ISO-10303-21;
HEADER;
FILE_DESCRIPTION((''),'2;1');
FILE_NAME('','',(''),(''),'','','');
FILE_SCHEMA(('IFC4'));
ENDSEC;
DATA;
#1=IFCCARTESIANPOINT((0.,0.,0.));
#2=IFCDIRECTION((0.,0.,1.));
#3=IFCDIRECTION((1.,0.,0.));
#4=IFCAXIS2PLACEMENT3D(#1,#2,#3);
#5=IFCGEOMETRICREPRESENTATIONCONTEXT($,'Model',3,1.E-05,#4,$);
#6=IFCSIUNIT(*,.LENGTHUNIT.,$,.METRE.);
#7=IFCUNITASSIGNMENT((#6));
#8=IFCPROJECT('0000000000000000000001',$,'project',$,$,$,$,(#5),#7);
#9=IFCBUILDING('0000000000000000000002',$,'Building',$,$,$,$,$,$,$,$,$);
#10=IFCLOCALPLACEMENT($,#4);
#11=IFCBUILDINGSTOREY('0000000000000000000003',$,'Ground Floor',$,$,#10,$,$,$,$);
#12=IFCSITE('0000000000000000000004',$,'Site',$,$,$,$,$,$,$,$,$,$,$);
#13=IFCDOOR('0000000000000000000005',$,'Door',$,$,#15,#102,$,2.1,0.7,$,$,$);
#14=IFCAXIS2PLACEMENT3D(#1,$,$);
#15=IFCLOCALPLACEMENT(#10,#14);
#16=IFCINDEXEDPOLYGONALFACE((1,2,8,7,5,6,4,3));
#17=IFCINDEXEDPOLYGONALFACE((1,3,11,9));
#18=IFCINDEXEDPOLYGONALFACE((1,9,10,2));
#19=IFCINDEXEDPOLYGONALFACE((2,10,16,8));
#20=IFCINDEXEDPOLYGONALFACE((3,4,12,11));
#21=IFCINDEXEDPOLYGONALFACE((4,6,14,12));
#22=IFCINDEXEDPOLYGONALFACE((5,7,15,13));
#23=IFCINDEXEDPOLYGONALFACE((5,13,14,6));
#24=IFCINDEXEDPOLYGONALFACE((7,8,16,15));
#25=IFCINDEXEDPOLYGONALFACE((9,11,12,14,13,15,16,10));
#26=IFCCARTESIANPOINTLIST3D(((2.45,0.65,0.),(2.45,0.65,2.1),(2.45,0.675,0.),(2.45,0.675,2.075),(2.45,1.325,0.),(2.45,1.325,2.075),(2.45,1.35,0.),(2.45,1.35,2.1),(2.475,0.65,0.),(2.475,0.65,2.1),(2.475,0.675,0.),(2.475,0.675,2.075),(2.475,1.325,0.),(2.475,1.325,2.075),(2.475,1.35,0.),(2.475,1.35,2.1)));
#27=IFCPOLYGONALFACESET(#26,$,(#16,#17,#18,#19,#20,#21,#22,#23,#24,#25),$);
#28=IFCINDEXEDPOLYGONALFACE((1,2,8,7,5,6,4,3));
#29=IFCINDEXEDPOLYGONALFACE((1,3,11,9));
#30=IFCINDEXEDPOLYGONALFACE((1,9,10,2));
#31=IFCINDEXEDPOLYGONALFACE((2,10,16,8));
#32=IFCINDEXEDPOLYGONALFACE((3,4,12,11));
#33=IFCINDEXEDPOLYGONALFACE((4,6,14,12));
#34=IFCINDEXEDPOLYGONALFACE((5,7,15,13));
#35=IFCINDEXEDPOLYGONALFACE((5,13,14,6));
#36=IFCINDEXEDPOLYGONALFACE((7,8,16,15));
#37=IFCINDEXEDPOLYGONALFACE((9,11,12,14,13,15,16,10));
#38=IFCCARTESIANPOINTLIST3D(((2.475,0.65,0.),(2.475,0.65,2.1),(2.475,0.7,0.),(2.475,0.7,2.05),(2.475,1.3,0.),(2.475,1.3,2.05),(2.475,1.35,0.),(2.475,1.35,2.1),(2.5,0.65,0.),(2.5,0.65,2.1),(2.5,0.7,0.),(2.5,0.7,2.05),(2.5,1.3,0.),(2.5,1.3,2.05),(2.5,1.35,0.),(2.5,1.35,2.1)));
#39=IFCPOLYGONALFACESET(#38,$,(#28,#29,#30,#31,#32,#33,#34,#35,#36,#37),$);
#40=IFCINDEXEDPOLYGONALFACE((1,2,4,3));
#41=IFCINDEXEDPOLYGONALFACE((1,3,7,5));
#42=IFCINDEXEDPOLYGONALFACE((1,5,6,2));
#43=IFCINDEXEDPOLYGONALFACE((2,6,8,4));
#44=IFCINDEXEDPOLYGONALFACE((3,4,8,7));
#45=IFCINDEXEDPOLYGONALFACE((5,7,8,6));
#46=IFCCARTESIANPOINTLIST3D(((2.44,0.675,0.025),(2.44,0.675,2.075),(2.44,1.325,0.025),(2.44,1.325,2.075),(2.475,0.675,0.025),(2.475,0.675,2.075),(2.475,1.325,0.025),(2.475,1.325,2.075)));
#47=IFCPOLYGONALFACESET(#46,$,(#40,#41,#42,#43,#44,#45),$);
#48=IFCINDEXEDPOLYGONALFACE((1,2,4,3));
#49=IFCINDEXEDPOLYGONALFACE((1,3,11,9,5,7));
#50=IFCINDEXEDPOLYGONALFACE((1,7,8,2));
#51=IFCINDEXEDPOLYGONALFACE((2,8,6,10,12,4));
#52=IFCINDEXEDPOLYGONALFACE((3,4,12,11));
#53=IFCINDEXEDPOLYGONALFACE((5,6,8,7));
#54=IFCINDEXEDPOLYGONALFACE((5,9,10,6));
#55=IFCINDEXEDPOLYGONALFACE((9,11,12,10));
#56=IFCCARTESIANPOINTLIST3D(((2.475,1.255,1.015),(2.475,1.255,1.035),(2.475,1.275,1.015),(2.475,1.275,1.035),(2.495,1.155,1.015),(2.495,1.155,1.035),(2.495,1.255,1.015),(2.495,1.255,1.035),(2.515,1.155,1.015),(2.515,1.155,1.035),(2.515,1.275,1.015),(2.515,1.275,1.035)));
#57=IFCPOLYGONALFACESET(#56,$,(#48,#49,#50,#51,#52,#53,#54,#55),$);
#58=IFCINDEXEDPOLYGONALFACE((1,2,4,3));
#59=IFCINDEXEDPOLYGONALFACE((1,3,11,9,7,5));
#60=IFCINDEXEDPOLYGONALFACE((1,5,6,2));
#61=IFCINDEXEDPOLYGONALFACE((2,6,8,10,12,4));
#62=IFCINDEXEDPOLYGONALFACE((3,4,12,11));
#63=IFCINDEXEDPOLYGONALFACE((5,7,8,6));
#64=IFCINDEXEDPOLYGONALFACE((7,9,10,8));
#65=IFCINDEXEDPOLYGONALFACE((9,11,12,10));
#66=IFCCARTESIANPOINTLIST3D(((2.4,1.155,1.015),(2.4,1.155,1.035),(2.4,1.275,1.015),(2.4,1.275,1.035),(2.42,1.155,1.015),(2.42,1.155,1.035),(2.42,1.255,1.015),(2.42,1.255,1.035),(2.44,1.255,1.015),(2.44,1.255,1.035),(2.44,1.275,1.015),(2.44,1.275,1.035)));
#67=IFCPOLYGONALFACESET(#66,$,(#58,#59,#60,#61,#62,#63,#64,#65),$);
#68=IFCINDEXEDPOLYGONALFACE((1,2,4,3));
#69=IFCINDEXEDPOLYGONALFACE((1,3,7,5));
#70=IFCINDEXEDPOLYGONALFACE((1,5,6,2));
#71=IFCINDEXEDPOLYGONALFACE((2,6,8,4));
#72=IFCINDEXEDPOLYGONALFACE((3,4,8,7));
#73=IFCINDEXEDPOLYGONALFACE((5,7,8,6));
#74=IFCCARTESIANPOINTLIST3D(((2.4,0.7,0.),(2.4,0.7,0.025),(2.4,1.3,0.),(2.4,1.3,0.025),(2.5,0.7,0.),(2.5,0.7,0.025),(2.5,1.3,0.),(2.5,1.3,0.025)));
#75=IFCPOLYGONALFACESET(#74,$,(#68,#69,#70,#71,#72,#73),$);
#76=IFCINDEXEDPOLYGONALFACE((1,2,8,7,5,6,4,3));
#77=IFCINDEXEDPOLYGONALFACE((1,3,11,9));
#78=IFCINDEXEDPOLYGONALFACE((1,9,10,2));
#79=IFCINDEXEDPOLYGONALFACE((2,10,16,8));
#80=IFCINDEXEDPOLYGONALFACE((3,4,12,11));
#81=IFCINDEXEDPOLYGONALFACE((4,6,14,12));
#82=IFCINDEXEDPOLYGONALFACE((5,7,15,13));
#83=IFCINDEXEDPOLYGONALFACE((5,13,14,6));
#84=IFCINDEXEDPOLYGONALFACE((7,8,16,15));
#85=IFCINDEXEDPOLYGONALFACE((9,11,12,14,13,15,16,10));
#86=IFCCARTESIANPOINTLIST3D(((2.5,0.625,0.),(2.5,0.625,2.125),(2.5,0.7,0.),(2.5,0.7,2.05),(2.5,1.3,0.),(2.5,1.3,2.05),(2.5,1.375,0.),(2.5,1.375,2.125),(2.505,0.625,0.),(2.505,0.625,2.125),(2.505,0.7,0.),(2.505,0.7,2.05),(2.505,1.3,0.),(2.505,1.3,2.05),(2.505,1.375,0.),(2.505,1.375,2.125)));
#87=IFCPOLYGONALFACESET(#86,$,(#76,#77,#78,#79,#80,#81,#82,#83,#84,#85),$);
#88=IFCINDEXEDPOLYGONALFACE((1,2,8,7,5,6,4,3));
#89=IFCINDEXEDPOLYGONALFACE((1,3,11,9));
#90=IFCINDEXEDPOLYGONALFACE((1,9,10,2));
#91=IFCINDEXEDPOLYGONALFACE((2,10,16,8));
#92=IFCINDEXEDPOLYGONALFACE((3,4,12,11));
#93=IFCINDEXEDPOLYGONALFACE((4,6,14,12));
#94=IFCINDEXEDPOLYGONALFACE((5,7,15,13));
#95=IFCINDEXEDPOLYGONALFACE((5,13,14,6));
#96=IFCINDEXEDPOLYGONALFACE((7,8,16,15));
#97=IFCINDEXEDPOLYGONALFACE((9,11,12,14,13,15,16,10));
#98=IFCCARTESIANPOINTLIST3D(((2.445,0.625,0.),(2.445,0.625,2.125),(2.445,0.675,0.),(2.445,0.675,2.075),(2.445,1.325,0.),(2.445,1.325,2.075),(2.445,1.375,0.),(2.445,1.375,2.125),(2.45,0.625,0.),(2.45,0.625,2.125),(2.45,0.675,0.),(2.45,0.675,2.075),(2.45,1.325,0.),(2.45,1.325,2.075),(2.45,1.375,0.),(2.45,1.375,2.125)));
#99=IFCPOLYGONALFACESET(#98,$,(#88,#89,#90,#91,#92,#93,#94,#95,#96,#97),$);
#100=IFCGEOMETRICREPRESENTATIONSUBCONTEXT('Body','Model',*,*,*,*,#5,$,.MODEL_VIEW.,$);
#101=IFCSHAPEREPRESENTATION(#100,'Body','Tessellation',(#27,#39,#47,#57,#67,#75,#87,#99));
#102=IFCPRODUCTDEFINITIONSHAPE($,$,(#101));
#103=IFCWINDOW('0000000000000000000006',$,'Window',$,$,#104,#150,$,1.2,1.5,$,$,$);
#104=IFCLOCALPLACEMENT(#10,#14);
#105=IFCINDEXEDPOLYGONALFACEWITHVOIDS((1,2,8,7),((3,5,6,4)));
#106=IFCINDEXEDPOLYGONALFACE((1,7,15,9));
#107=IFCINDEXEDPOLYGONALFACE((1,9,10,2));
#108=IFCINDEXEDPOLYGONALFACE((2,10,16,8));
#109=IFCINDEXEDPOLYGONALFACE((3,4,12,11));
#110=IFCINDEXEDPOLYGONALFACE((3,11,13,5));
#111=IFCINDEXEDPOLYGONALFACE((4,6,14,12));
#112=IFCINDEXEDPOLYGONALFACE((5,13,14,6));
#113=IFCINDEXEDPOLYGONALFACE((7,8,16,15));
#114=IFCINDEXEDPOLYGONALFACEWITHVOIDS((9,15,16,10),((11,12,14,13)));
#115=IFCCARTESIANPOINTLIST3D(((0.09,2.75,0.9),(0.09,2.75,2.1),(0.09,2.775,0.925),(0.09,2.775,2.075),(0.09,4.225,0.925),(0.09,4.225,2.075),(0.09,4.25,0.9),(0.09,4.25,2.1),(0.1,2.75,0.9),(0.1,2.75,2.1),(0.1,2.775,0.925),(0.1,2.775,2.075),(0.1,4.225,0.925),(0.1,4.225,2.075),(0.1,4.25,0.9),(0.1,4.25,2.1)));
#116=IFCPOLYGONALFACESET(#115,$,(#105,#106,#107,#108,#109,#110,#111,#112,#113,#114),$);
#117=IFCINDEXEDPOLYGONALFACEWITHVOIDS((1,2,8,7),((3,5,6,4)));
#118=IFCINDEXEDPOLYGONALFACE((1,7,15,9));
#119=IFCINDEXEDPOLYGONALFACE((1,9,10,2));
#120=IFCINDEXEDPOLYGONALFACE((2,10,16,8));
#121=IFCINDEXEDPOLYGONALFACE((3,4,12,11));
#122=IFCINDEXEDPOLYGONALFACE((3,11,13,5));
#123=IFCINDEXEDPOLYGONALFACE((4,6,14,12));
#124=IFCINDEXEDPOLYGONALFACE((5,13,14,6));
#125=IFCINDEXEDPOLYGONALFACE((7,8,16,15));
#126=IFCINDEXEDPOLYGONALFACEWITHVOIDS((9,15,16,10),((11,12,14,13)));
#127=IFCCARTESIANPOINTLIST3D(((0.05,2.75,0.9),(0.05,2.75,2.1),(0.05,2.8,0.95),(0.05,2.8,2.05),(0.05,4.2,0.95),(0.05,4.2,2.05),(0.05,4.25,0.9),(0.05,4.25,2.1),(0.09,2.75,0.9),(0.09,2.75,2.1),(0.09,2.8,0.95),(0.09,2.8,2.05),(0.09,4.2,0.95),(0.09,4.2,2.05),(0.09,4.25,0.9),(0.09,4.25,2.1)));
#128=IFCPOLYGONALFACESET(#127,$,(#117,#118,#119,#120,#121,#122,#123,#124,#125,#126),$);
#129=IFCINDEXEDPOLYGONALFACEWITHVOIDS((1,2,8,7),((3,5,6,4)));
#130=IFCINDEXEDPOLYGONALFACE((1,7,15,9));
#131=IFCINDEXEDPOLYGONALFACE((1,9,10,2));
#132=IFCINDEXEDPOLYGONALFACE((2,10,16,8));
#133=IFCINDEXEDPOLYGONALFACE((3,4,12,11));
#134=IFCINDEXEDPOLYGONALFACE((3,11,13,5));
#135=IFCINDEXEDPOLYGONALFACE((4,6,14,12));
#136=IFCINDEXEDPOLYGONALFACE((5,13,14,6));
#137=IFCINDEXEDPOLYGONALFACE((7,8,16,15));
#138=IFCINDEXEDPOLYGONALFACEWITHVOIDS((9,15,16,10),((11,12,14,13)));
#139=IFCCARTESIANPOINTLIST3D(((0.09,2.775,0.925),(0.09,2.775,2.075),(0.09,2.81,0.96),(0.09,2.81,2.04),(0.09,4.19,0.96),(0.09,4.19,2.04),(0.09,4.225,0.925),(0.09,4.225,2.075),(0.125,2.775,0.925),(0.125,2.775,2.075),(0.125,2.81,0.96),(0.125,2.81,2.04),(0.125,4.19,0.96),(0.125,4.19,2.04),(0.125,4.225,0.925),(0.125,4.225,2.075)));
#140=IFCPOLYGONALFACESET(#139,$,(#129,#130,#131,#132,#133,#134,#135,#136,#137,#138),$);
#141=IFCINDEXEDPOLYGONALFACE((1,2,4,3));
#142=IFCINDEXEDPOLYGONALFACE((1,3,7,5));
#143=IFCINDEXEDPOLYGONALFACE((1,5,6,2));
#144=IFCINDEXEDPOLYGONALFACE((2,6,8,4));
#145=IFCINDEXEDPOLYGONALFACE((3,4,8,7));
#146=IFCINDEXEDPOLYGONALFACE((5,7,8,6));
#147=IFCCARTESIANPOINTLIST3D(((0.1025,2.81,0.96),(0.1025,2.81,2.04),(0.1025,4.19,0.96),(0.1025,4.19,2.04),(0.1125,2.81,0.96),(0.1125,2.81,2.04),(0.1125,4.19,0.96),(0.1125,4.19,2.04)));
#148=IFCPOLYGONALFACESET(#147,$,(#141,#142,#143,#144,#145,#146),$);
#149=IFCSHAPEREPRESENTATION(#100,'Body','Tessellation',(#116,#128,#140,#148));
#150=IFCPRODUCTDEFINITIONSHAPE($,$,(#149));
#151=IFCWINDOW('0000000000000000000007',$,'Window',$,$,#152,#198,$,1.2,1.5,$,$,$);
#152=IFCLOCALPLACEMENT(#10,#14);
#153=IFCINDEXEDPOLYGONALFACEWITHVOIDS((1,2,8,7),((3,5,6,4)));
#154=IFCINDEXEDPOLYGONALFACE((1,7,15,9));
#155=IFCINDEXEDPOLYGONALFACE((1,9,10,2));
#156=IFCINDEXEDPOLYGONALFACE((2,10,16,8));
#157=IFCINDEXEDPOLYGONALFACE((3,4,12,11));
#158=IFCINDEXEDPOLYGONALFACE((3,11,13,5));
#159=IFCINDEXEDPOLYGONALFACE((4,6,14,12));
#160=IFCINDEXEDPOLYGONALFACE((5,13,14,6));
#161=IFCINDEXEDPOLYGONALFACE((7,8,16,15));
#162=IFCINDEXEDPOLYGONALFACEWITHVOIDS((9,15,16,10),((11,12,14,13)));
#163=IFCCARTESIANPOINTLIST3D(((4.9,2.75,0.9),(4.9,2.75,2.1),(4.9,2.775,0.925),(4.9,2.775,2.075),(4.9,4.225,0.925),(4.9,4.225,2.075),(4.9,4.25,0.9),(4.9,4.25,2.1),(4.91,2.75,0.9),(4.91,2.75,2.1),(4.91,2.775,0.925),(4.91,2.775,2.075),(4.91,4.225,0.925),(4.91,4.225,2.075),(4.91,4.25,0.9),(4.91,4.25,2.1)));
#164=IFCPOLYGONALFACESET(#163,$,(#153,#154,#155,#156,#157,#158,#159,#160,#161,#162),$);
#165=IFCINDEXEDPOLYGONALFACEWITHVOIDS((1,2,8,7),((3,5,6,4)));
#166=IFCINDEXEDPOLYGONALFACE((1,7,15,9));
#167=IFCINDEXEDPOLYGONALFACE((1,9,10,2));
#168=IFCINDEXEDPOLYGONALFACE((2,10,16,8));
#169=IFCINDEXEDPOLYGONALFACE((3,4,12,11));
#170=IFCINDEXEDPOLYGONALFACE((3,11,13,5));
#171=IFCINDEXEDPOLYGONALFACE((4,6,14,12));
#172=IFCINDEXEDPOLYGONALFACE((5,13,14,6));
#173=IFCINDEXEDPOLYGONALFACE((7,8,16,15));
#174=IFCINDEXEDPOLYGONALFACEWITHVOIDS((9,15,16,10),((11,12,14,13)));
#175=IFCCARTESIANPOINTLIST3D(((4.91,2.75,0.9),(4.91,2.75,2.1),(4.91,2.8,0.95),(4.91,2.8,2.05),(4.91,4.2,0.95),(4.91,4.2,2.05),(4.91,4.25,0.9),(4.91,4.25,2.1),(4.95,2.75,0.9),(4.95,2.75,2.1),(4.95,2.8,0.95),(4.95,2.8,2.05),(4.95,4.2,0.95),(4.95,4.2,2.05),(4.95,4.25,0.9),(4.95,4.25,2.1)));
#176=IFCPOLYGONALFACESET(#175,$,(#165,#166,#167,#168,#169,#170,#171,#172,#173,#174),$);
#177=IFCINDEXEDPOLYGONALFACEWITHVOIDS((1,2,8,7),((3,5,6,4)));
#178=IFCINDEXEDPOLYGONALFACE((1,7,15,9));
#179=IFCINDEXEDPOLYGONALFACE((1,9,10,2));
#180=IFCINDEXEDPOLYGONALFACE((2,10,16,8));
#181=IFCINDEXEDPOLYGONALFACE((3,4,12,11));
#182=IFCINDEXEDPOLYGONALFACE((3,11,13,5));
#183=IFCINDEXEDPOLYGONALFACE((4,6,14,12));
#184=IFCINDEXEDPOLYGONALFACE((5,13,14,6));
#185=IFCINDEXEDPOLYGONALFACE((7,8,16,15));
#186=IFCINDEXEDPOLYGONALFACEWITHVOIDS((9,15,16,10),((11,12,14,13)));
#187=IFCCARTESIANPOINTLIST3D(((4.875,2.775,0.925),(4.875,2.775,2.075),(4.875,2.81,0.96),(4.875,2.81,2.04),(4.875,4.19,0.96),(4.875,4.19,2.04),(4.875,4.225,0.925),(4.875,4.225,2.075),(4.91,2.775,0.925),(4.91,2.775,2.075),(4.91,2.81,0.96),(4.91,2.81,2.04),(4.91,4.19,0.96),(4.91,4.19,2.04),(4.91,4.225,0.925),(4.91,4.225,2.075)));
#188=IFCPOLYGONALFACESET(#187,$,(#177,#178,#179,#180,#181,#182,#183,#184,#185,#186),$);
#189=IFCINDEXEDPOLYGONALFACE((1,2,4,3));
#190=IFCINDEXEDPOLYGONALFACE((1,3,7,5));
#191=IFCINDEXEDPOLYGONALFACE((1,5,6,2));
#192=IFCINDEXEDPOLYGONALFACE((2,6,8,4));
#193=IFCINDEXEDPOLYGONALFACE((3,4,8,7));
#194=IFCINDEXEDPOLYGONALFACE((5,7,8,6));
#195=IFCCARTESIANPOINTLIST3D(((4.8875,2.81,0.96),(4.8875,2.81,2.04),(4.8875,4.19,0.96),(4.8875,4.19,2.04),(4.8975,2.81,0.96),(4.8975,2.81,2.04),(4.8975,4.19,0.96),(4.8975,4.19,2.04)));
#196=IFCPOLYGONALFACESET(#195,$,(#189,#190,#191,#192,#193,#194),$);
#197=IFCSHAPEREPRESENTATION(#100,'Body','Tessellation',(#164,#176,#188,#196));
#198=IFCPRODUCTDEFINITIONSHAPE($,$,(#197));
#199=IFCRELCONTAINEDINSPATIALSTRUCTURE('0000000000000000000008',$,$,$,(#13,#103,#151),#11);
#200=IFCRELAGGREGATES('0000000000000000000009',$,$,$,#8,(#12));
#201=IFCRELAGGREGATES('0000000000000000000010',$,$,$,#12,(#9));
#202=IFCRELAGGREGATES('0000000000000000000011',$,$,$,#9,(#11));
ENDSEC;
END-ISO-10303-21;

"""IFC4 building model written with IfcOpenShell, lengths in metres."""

from ifc_helpers import new_model, si_unit, frame, origin_with_axes, place, context, subcontext, project, spatial, line, indexed_curve, outline, extrude, element, save


model = new_model("IFC4")

# Units and contexts
model_context = context("Model", 3, precision=1e-05, world=origin_with_axes())
body_context = subcontext(model_context, "Body", "Model", "MODEL_VIEW")
ifc_project = project(units=[si_unit("LENGTHUNIT", "METRE")], contexts=[model_context])

# Site, building, storey
site = spatial("IfcSite", under=ifc_project, Name="Site")
building = spatial("IfcBuilding", under=site, Name="Building")
storey_placement = place(None, origin_with_axes())
storey = spatial("IfcBuildingStorey", under=building, at=storey_placement, Name="Ground Floor")

# Door
door_1_placement = place(storey_placement, frame((2.5, 0.65, 0.0), z_axis=(0.0, 0.0, 1.0), x_axis=(0.0, 1.0, 0.0)))
element("IfcDoor", 1, at=door_1_placement, inside=storey, Name="Door", OverallHeight=2.1, OverallWidth=0.7, context=body_context, shape_type="SweptSolid", body=[
    extrude(outline(indexed_curve([(0.0, 0.0), (0.0, 2.1), (0.7, 2.1), (0.7, 0.0), (0.675, 0.0), (0.675, 2.075), (0.025, 2.075), (0.025, 0.0)], segments=[line(1, 2, 3, 4, 5, 6, 7, 8, 1)])), frame((0.0, 0.025, 0.0), z_axis=(0.0, -1.0, 0.0), x_axis=(1.0, 0.0, 0.0)), (0.0, 0.0, -1.0), 0.025),
    extrude(outline(indexed_curve([(0.0, 0.0), (0.0, 2.1), (0.7, 2.1), (0.7, 0.0), (0.65, 0.0), (0.65, 2.05), (0.05, 2.05), (0.05, 0.0)], segments=[line(1, 2, 3, 4, 5, 6, 7, 8, 1)])), frame((0.0, 0.0, 0.0), z_axis=(0.0, -1.0, 0.0), x_axis=(1.0, 0.0, 0.0)), (0.0, 0.0, -1.0), 0.025),
    extrude(outline(indexed_curve([(0.0, 0.0), (0.65, 0.0), (0.65, 0.035), (0.0, 0.035)], segments=[line(1, 2, 3, 4, 1)])), frame((0.025, 0.025, 0.025), z_axis=(0.0, 0.0, 1.0), x_axis=(1.0, 0.0, 0.0)), (0.0, 0.0, 1.0), 2.05),
    extrude(outline(indexed_curve([(0.0, 0.0), (0.0, -0.04), (-0.12, -0.04), (-0.12, -0.02), (-0.02, -0.02), (-0.02, 0.0)], segments=[line(1, 2, 3, 4, 5, 6, 1)])), frame((0.625, 0.025, 1.015), z_axis=(0.0, 0.0, 1.0), x_axis=(1.0, 0.0, 0.0)), (0.0, 0.0, 1.0), 0.02),
    extrude(outline(indexed_curve([(0.0, 0.0), (0.0, 0.04), (-0.12, 0.04), (-0.12, 0.02), (-0.02, 0.02), (-0.02, 0.0)], segments=[line(1, 2, 3, 4, 5, 6, 1)])), frame((0.625, 0.06, 1.015), z_axis=(0.0, 0.0, 1.0), x_axis=(1.0, 0.0, 0.0)), (0.0, 0.0, 1.0), 0.02),
    extrude(outline(indexed_curve([(0.0, 0.0), (0.6, 0.0), (0.6, 0.1), (0.0, 0.1)], segments=[line(1, 2, 3, 4, 1)])), frame((0.05, 0.0, 0.0), z_axis=(0.0, 0.0, 1.0), x_axis=(1.0, 0.0, 0.0)), (0.0, 0.0, 1.0), 0.025),
    extrude(outline(indexed_curve([(0.0, 0.0), (0.0, 2.125), (0.75, 2.125), (0.75, 0.0), (0.675, 0.0), (0.675, 2.05), (0.075, 2.05), (0.075, 0.0)], segments=[line(1, 2, 3, 4, 5, 6, 7, 8, 1)])), frame((-0.025, -0.005, 0.0), z_axis=(0.0, -1.0, 0.0), x_axis=(1.0, 0.0, 0.0)), (0.0, 0.0, -1.0), 0.005),
    extrude(outline(indexed_curve([(0.0, 0.0), (0.0, 2.125), (0.75, 2.125), (0.75, 0.0), (0.7, 0.0), (0.7, 2.075), (0.05, 2.075), (0.05, 0.0)], segments=[line(1, 2, 3, 4, 5, 6, 7, 8, 1)])), frame((-0.025, 0.05, 0.0), z_axis=(0.0, -1.0, 0.0), x_axis=(1.0, 0.0, 0.0)), (0.0, 0.0, -1.0), 0.005),
])

# Windows
for number, where, z_axis, x_axis, name in (
    (2, (0.0, 4.25, 0.9), (0.0, 0.0, 1.0), (0.0, -1.0, 0.0), "Window"),
    (3, (5.0, 2.75, 0.9), (0.0, 0.0, 1.0), (0.0, 1.0, 0.0), "Window"),
):
    element("IfcWindow", number, at=place(storey_placement, frame(where, z_axis=z_axis, x_axis=x_axis)), inside=storey, Name=name, OverallHeight=1.2, OverallWidth=1.5, context=body_context, shape_type="SweptSolid", body=[
        extrude(outline(indexed_curve([(0.0, 0.0), (1.5, 0.0), (1.5, 1.2), (0.0, 1.2)], segments=[line(1, 2, 3, 4, 1)]), holes=[indexed_curve([(0.025, 0.025), (1.475, 0.025), (1.475, 1.175), (0.025, 1.175)], segments=[line(1, 2, 3, 4, 1)])]), frame((0.0, 0.09, 0.0), z_axis=(0.0, -1.0, 0.0), x_axis=(1.0, 0.0, 0.0)), (0.0, 0.0, -1.0), 0.01),
        extrude(outline(indexed_curve([(0.0, 0.0), (1.5, 0.0), (1.5, 1.2), (0.0, 1.2)], segments=[line(1, 2, 3, 4, 1)]), holes=[indexed_curve([(0.05, 0.05), (1.45, 0.05), (1.45, 1.15), (0.05, 1.15)], segments=[line(1, 2, 3, 4, 1)])]), frame((0.0, 0.05, 0.0), z_axis=(0.0, -1.0, 0.0), x_axis=(1.0, 0.0, 0.0)), (0.0, 0.0, -1.0), 0.04),
        extrude(outline(indexed_curve([(0.0, 0.0), (1.45, 0.0), (1.45, 1.15), (0.0, 1.15)], segments=[line(1, 2, 3, 4, 1)]), holes=[indexed_curve([(0.035, 0.035), (1.415, 0.035), (1.415, 1.115), (0.035, 1.115)], segments=[line(1, 2, 3, 4, 1)])]), frame((0.025, 0.09, 0.025), z_axis=(0.0, -1.0, 0.0), x_axis=(1.0, 0.0, 0.0)), (0.0, 0.0, -1.0), 0.035),
        extrude(outline(indexed_curve([(0.035, 0.035), (1.415, 0.035), (1.415, 1.115), (0.035, 1.115)], segments=[line(1, 2, 3, 4, 1)])), frame((0.025, 0.1025, 0.025), z_axis=(0.0, -1.0, 0.0), x_axis=(1.0, 0.0, 0.0)), (0.0, 0.0, -1.0), 0.01),
    ])

save(model, "model.ifc")
